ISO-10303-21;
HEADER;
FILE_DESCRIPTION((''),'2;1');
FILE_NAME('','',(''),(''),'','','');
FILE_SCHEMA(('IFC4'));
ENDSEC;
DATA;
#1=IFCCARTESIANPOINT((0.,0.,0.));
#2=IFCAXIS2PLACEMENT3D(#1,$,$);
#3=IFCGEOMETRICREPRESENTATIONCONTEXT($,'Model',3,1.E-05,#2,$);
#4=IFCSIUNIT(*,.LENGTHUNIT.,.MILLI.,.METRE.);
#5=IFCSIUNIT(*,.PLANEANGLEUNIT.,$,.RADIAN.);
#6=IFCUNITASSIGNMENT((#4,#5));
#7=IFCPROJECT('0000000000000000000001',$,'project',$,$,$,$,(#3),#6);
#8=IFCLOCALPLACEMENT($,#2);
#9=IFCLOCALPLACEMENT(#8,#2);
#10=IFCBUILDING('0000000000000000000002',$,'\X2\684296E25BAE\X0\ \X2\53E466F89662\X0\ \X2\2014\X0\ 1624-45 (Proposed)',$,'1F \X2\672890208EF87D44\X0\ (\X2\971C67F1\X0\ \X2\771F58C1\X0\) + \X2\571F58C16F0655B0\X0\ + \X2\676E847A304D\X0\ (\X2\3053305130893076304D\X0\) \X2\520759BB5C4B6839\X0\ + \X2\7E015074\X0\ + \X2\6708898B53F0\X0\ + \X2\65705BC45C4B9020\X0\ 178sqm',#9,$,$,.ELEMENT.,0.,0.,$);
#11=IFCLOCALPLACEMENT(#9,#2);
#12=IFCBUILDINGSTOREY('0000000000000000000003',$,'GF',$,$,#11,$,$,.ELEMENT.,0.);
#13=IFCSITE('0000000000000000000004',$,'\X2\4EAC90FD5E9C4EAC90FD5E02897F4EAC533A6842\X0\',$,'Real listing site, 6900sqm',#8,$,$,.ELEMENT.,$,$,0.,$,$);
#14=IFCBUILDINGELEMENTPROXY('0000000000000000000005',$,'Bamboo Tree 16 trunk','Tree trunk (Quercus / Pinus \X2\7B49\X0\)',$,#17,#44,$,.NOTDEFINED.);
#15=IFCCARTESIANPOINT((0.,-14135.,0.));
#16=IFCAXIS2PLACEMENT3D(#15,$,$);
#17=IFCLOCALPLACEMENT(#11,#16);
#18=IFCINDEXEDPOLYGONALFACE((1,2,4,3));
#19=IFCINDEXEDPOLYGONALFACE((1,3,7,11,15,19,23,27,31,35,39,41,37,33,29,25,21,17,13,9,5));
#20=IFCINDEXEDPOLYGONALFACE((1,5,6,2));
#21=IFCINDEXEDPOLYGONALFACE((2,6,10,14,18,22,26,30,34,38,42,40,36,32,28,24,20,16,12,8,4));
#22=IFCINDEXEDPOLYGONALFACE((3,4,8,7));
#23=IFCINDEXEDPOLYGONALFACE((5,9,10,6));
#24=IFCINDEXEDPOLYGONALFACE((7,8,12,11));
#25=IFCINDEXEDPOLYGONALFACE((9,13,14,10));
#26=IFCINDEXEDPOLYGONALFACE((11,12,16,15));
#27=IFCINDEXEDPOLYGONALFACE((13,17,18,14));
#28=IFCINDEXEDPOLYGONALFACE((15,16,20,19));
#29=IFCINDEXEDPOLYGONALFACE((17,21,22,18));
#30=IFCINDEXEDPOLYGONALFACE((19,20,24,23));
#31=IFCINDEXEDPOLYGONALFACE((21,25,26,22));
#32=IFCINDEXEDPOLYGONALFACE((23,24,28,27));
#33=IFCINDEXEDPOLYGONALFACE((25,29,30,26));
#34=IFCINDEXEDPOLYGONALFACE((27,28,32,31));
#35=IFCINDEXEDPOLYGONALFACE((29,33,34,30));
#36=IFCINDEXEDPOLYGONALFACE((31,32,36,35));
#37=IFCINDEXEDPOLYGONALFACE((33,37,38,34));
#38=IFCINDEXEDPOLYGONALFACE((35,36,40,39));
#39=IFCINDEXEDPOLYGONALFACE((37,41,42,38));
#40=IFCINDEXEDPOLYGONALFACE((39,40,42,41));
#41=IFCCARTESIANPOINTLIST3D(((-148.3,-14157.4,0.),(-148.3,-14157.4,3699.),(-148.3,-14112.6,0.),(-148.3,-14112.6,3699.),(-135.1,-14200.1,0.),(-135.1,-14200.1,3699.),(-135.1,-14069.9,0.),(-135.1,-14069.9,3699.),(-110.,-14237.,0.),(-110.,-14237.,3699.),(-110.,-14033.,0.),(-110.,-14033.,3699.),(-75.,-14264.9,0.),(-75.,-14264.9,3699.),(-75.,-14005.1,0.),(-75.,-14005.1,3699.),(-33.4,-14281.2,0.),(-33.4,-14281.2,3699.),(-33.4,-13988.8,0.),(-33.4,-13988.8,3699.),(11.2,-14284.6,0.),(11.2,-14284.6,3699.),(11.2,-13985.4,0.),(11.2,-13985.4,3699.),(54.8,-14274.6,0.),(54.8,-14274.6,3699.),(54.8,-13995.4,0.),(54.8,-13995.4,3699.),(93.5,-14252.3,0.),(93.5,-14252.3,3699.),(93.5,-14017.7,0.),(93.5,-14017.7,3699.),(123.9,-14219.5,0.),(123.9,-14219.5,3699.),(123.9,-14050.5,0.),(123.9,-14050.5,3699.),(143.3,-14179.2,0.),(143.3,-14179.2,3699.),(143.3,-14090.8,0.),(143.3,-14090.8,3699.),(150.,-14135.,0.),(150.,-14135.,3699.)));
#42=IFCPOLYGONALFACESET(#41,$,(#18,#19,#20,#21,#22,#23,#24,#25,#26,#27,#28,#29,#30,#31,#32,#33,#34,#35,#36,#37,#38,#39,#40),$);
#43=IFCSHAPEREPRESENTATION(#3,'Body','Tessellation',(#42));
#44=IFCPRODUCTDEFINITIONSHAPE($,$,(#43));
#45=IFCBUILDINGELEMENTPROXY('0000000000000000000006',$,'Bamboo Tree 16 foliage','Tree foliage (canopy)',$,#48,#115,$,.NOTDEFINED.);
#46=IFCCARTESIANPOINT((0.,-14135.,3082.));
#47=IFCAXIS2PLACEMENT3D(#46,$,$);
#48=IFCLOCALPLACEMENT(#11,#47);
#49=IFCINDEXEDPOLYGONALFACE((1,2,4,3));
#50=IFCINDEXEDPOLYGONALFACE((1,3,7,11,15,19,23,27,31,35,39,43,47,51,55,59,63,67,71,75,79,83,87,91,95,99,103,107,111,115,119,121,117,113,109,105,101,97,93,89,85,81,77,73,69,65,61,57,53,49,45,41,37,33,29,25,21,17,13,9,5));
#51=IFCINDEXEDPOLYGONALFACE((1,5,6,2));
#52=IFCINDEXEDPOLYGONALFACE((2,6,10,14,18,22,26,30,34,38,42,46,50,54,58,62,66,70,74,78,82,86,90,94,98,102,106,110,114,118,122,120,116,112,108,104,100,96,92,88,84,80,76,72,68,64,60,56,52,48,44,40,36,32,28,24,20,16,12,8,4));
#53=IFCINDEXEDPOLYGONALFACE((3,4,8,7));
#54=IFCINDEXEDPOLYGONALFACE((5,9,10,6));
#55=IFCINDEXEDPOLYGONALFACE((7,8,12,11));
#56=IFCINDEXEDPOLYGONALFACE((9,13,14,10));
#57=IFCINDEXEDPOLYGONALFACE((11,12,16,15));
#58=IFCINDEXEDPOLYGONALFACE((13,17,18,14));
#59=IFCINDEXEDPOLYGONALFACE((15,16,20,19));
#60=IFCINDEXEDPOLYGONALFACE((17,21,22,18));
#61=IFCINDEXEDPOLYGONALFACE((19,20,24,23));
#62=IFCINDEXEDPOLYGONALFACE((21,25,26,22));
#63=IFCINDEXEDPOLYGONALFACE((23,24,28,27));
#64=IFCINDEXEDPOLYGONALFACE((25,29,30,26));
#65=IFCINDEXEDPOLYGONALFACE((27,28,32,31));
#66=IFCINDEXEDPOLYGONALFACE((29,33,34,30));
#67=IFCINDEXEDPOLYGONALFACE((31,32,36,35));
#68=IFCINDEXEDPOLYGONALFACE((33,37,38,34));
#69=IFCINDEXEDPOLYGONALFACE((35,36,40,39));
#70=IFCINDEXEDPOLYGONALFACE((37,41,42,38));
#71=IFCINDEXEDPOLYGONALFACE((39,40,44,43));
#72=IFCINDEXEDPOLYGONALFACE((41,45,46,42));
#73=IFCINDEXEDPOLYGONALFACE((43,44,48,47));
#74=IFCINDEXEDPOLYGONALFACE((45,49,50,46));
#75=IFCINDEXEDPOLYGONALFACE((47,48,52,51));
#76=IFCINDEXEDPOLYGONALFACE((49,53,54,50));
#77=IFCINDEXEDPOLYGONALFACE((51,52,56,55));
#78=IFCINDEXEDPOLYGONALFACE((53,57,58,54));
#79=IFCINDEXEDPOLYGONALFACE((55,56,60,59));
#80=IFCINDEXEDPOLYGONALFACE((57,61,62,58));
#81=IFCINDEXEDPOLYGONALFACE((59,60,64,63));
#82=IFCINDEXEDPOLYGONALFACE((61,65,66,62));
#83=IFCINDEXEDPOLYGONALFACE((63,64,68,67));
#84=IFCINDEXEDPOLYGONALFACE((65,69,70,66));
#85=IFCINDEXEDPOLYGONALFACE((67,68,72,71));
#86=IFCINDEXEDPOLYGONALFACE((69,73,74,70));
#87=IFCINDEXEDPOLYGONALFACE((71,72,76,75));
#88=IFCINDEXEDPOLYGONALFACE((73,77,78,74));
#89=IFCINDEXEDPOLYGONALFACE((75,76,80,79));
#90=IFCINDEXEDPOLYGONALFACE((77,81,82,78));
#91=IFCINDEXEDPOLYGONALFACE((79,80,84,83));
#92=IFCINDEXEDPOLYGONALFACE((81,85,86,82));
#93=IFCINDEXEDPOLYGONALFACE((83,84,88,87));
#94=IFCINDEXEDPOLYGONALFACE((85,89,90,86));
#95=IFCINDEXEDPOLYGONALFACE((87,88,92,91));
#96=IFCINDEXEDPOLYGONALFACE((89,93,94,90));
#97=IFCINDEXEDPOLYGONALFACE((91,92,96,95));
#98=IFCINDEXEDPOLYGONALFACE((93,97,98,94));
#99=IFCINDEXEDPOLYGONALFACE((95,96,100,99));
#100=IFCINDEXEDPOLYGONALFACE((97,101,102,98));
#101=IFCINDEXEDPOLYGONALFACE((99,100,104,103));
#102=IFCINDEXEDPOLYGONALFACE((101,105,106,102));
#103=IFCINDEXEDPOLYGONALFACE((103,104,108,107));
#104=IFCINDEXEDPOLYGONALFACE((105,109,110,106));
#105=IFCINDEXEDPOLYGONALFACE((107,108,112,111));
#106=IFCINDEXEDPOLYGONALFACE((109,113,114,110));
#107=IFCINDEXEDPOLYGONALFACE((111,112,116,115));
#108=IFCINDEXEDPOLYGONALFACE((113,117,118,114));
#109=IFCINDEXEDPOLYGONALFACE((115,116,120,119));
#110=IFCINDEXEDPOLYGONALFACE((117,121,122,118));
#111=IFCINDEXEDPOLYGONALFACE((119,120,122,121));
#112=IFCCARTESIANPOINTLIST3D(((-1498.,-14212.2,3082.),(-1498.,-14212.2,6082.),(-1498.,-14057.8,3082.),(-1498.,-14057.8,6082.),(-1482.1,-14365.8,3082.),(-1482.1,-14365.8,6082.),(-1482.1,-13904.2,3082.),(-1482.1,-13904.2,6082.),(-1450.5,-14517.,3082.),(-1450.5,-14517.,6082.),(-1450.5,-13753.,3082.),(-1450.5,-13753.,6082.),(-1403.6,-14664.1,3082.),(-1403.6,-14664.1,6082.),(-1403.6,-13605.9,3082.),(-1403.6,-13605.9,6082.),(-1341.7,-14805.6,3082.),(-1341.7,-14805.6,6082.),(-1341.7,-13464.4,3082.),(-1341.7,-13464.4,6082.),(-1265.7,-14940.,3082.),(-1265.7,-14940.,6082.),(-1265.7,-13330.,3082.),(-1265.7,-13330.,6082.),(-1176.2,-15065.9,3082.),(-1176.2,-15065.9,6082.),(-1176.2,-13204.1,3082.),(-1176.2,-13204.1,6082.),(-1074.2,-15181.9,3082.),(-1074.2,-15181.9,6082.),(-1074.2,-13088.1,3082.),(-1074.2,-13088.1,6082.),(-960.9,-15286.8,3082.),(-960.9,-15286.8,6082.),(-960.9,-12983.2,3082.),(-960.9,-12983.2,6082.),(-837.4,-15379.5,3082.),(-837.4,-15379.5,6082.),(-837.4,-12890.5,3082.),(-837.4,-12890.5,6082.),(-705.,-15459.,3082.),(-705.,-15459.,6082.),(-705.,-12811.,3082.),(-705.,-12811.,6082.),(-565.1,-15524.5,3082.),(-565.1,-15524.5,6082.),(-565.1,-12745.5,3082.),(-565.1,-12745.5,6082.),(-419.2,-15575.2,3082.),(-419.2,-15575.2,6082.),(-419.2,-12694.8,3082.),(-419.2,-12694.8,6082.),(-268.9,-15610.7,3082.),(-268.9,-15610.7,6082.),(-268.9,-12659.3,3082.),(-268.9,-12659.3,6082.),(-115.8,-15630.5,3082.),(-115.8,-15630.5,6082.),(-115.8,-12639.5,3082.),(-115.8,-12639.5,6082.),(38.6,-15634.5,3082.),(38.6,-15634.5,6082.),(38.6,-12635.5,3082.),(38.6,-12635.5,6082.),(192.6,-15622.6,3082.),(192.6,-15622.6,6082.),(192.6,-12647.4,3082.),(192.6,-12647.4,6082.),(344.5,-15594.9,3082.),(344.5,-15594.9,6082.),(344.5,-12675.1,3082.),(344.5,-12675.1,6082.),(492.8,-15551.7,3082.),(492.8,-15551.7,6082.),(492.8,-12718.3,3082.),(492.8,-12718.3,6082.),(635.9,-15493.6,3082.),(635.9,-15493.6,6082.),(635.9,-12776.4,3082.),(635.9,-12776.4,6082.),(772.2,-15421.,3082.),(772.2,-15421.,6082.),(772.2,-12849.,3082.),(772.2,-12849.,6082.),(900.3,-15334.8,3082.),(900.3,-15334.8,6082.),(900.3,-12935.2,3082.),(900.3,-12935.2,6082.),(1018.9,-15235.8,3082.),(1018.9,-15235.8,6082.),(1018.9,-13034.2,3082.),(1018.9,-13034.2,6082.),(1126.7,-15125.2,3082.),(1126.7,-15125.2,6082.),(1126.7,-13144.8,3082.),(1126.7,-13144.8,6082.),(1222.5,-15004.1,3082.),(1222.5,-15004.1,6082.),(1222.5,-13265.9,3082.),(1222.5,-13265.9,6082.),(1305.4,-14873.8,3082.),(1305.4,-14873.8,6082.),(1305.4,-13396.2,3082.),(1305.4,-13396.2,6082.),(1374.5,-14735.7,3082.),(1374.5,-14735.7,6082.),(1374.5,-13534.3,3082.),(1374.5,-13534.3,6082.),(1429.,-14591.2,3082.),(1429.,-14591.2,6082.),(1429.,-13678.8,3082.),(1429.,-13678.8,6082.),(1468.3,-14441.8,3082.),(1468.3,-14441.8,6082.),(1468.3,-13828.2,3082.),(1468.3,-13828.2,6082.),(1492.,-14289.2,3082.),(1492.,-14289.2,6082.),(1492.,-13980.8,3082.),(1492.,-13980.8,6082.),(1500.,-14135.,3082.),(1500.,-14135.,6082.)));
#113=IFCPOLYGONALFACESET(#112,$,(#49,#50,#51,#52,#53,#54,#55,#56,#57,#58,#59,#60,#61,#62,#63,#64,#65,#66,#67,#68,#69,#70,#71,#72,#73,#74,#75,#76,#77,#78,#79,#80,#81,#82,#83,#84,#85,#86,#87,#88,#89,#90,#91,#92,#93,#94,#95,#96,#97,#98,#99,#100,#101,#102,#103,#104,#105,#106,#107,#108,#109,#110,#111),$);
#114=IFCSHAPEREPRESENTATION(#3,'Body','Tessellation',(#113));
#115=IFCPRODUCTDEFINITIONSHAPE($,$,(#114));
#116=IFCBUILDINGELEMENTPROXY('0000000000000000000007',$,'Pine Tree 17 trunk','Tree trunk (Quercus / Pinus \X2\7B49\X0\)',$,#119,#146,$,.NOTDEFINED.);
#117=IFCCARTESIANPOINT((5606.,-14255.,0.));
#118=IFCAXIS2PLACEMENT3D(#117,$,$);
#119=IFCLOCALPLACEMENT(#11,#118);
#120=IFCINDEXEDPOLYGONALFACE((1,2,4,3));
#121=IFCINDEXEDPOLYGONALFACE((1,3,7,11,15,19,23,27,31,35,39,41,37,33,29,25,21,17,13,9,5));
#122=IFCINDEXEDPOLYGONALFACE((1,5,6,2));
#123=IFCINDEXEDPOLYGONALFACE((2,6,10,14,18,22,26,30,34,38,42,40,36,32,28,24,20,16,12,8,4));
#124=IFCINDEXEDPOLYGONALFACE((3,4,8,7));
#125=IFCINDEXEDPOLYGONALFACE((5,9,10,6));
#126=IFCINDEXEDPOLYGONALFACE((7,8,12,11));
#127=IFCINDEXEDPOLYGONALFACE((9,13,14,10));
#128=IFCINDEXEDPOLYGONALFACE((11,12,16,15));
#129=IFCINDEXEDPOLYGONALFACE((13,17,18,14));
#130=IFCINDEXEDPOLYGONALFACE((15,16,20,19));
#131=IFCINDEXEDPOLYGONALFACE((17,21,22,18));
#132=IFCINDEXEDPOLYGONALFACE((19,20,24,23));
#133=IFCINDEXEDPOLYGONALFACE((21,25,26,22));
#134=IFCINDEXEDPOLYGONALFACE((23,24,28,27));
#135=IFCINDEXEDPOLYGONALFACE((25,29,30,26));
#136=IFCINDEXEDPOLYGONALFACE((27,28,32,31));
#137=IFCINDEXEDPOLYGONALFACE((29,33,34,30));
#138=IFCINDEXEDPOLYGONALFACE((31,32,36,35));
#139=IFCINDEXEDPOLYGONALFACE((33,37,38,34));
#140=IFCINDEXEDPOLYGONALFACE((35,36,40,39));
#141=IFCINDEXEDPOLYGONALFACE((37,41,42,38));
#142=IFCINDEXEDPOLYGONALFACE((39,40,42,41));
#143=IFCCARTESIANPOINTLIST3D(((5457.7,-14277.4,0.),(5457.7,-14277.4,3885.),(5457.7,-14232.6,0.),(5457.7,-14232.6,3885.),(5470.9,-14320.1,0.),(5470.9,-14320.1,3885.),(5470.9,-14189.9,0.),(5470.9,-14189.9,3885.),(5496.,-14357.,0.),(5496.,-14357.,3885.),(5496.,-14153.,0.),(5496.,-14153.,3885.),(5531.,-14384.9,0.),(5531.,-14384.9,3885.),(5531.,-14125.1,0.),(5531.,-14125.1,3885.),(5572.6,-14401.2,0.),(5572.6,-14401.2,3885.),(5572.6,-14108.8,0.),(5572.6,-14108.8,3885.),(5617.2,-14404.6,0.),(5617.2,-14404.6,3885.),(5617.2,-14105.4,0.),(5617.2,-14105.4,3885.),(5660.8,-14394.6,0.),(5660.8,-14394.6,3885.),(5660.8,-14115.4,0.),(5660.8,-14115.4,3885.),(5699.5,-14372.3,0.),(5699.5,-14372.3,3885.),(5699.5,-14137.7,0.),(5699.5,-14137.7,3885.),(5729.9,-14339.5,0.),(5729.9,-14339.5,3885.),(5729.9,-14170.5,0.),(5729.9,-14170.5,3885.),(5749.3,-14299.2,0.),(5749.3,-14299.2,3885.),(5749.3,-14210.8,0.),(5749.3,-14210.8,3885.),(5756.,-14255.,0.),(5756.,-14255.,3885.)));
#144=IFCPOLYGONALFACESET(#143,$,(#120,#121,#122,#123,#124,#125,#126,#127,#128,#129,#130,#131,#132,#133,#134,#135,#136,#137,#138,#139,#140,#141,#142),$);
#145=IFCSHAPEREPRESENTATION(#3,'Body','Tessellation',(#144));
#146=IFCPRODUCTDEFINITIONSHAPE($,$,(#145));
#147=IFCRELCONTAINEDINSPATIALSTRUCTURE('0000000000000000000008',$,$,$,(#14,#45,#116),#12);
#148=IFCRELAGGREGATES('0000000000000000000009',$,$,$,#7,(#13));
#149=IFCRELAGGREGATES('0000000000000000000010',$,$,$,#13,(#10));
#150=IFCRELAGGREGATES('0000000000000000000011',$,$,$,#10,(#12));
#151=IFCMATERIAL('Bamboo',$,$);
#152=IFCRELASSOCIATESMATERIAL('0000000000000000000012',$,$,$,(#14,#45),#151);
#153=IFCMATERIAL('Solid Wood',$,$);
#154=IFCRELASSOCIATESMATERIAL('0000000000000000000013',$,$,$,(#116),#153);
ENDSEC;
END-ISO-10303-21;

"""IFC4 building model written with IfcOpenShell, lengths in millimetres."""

from ifc_helpers import new_model, si_unit, frame, origin, origin_2d, place, context, project, spatial, circle, extrude, material, element, save


model = new_model("IFC4")

# Units and contexts
model_context = context("Model", 3, precision=1e-05, world=origin())
ifc_project = project(units=[si_unit("LENGTHUNIT", "METRE", prefix="MILLI"), si_unit("PLANEANGLEUNIT", "RADIAN")], contexts=[model_context])

# Site, building, storey
site_placement = place(None, origin())
site = spatial("IfcSite", under=ifc_project, at=site_placement, Name="京都府京都市西京区桂", ObjectType="Real listing site, 6900sqm", CompositionType="ELEMENT", RefElevation=0.0)
building_placement = place(site_placement, origin())
building = spatial("IfcBuilding", under=site, at=building_placement, Name="桂離宮 古書院 — 1624-45 (Proposed)", ObjectType="1F 木造軸組 (霜柱 真壁) + 土壁漆喰 + 杮葺き (こけらぶき) 切妻屋根 + 縁側 + 月見台 + 数寄屋造 178sqm", CompositionType="ELEMENT", ElevationOfRefHeight=0.0, ElevationOfTerrain=0.0)
storey_placement = place(building_placement, origin())
storey = spatial("IfcBuildingStorey", under=building, at=storey_placement, Name="GF", CompositionType="ELEMENT", Elevation=0.0)

# Shared definitions
ifc_material_1 = material(Name="Solid Wood")

# Shared definitions
ifc_material_2 = material(Name="Bamboo")

# Building element proxies
proxy_1_placement = place(storey_placement, frame((0.0, -14135.0, 0.0)))
element("IfcBuildingElementProxy", 1, at=proxy_1_placement, inside=storey, material=ifc_material_2, Name="Bamboo Tree 16 trunk", Description="Tree trunk (Quercus / Pinus 等)", PredefinedType="NOTDEFINED", context=model_context, shape_type="SweptSolid", body=[
    extrude(circle(Radius=150.0, at=origin_2d()), frame((0.0, -14135.0, 0.0)), (0.0, 0.0, 1.0), 3699.0),
])
proxy_2_placement = place(storey_placement, frame((0.0, -14135.0, 3082.0)))
element("IfcBuildingElementProxy", 2, at=proxy_2_placement, inside=storey, material=ifc_material_2, Name="Bamboo Tree 16 foliage", Description="Tree foliage (canopy)", PredefinedType="NOTDEFINED", context=model_context, shape_type="SweptSolid", body=[
    extrude(circle(Radius=1500.0, at=origin_2d()), frame((0.0, -14135.0, 3082.0)), (0.0, 0.0, 1.0), 3000.0),
])
proxy_3_placement = place(storey_placement, frame((5606.0, -14255.0, 0.0)))
element("IfcBuildingElementProxy", 3, at=proxy_3_placement, inside=storey, material=ifc_material_1, Name="Pine Tree 17 trunk", Description="Tree trunk (Quercus / Pinus 等)", PredefinedType="NOTDEFINED", context=model_context, shape_type="SweptSolid", body=[
    extrude(circle(Radius=150.0, at=origin_2d()), frame((5606.0, -14255.0, 0.0)), (0.0, 0.0, 1.0), 3885.0),
])

save(model, "model.ifc")
